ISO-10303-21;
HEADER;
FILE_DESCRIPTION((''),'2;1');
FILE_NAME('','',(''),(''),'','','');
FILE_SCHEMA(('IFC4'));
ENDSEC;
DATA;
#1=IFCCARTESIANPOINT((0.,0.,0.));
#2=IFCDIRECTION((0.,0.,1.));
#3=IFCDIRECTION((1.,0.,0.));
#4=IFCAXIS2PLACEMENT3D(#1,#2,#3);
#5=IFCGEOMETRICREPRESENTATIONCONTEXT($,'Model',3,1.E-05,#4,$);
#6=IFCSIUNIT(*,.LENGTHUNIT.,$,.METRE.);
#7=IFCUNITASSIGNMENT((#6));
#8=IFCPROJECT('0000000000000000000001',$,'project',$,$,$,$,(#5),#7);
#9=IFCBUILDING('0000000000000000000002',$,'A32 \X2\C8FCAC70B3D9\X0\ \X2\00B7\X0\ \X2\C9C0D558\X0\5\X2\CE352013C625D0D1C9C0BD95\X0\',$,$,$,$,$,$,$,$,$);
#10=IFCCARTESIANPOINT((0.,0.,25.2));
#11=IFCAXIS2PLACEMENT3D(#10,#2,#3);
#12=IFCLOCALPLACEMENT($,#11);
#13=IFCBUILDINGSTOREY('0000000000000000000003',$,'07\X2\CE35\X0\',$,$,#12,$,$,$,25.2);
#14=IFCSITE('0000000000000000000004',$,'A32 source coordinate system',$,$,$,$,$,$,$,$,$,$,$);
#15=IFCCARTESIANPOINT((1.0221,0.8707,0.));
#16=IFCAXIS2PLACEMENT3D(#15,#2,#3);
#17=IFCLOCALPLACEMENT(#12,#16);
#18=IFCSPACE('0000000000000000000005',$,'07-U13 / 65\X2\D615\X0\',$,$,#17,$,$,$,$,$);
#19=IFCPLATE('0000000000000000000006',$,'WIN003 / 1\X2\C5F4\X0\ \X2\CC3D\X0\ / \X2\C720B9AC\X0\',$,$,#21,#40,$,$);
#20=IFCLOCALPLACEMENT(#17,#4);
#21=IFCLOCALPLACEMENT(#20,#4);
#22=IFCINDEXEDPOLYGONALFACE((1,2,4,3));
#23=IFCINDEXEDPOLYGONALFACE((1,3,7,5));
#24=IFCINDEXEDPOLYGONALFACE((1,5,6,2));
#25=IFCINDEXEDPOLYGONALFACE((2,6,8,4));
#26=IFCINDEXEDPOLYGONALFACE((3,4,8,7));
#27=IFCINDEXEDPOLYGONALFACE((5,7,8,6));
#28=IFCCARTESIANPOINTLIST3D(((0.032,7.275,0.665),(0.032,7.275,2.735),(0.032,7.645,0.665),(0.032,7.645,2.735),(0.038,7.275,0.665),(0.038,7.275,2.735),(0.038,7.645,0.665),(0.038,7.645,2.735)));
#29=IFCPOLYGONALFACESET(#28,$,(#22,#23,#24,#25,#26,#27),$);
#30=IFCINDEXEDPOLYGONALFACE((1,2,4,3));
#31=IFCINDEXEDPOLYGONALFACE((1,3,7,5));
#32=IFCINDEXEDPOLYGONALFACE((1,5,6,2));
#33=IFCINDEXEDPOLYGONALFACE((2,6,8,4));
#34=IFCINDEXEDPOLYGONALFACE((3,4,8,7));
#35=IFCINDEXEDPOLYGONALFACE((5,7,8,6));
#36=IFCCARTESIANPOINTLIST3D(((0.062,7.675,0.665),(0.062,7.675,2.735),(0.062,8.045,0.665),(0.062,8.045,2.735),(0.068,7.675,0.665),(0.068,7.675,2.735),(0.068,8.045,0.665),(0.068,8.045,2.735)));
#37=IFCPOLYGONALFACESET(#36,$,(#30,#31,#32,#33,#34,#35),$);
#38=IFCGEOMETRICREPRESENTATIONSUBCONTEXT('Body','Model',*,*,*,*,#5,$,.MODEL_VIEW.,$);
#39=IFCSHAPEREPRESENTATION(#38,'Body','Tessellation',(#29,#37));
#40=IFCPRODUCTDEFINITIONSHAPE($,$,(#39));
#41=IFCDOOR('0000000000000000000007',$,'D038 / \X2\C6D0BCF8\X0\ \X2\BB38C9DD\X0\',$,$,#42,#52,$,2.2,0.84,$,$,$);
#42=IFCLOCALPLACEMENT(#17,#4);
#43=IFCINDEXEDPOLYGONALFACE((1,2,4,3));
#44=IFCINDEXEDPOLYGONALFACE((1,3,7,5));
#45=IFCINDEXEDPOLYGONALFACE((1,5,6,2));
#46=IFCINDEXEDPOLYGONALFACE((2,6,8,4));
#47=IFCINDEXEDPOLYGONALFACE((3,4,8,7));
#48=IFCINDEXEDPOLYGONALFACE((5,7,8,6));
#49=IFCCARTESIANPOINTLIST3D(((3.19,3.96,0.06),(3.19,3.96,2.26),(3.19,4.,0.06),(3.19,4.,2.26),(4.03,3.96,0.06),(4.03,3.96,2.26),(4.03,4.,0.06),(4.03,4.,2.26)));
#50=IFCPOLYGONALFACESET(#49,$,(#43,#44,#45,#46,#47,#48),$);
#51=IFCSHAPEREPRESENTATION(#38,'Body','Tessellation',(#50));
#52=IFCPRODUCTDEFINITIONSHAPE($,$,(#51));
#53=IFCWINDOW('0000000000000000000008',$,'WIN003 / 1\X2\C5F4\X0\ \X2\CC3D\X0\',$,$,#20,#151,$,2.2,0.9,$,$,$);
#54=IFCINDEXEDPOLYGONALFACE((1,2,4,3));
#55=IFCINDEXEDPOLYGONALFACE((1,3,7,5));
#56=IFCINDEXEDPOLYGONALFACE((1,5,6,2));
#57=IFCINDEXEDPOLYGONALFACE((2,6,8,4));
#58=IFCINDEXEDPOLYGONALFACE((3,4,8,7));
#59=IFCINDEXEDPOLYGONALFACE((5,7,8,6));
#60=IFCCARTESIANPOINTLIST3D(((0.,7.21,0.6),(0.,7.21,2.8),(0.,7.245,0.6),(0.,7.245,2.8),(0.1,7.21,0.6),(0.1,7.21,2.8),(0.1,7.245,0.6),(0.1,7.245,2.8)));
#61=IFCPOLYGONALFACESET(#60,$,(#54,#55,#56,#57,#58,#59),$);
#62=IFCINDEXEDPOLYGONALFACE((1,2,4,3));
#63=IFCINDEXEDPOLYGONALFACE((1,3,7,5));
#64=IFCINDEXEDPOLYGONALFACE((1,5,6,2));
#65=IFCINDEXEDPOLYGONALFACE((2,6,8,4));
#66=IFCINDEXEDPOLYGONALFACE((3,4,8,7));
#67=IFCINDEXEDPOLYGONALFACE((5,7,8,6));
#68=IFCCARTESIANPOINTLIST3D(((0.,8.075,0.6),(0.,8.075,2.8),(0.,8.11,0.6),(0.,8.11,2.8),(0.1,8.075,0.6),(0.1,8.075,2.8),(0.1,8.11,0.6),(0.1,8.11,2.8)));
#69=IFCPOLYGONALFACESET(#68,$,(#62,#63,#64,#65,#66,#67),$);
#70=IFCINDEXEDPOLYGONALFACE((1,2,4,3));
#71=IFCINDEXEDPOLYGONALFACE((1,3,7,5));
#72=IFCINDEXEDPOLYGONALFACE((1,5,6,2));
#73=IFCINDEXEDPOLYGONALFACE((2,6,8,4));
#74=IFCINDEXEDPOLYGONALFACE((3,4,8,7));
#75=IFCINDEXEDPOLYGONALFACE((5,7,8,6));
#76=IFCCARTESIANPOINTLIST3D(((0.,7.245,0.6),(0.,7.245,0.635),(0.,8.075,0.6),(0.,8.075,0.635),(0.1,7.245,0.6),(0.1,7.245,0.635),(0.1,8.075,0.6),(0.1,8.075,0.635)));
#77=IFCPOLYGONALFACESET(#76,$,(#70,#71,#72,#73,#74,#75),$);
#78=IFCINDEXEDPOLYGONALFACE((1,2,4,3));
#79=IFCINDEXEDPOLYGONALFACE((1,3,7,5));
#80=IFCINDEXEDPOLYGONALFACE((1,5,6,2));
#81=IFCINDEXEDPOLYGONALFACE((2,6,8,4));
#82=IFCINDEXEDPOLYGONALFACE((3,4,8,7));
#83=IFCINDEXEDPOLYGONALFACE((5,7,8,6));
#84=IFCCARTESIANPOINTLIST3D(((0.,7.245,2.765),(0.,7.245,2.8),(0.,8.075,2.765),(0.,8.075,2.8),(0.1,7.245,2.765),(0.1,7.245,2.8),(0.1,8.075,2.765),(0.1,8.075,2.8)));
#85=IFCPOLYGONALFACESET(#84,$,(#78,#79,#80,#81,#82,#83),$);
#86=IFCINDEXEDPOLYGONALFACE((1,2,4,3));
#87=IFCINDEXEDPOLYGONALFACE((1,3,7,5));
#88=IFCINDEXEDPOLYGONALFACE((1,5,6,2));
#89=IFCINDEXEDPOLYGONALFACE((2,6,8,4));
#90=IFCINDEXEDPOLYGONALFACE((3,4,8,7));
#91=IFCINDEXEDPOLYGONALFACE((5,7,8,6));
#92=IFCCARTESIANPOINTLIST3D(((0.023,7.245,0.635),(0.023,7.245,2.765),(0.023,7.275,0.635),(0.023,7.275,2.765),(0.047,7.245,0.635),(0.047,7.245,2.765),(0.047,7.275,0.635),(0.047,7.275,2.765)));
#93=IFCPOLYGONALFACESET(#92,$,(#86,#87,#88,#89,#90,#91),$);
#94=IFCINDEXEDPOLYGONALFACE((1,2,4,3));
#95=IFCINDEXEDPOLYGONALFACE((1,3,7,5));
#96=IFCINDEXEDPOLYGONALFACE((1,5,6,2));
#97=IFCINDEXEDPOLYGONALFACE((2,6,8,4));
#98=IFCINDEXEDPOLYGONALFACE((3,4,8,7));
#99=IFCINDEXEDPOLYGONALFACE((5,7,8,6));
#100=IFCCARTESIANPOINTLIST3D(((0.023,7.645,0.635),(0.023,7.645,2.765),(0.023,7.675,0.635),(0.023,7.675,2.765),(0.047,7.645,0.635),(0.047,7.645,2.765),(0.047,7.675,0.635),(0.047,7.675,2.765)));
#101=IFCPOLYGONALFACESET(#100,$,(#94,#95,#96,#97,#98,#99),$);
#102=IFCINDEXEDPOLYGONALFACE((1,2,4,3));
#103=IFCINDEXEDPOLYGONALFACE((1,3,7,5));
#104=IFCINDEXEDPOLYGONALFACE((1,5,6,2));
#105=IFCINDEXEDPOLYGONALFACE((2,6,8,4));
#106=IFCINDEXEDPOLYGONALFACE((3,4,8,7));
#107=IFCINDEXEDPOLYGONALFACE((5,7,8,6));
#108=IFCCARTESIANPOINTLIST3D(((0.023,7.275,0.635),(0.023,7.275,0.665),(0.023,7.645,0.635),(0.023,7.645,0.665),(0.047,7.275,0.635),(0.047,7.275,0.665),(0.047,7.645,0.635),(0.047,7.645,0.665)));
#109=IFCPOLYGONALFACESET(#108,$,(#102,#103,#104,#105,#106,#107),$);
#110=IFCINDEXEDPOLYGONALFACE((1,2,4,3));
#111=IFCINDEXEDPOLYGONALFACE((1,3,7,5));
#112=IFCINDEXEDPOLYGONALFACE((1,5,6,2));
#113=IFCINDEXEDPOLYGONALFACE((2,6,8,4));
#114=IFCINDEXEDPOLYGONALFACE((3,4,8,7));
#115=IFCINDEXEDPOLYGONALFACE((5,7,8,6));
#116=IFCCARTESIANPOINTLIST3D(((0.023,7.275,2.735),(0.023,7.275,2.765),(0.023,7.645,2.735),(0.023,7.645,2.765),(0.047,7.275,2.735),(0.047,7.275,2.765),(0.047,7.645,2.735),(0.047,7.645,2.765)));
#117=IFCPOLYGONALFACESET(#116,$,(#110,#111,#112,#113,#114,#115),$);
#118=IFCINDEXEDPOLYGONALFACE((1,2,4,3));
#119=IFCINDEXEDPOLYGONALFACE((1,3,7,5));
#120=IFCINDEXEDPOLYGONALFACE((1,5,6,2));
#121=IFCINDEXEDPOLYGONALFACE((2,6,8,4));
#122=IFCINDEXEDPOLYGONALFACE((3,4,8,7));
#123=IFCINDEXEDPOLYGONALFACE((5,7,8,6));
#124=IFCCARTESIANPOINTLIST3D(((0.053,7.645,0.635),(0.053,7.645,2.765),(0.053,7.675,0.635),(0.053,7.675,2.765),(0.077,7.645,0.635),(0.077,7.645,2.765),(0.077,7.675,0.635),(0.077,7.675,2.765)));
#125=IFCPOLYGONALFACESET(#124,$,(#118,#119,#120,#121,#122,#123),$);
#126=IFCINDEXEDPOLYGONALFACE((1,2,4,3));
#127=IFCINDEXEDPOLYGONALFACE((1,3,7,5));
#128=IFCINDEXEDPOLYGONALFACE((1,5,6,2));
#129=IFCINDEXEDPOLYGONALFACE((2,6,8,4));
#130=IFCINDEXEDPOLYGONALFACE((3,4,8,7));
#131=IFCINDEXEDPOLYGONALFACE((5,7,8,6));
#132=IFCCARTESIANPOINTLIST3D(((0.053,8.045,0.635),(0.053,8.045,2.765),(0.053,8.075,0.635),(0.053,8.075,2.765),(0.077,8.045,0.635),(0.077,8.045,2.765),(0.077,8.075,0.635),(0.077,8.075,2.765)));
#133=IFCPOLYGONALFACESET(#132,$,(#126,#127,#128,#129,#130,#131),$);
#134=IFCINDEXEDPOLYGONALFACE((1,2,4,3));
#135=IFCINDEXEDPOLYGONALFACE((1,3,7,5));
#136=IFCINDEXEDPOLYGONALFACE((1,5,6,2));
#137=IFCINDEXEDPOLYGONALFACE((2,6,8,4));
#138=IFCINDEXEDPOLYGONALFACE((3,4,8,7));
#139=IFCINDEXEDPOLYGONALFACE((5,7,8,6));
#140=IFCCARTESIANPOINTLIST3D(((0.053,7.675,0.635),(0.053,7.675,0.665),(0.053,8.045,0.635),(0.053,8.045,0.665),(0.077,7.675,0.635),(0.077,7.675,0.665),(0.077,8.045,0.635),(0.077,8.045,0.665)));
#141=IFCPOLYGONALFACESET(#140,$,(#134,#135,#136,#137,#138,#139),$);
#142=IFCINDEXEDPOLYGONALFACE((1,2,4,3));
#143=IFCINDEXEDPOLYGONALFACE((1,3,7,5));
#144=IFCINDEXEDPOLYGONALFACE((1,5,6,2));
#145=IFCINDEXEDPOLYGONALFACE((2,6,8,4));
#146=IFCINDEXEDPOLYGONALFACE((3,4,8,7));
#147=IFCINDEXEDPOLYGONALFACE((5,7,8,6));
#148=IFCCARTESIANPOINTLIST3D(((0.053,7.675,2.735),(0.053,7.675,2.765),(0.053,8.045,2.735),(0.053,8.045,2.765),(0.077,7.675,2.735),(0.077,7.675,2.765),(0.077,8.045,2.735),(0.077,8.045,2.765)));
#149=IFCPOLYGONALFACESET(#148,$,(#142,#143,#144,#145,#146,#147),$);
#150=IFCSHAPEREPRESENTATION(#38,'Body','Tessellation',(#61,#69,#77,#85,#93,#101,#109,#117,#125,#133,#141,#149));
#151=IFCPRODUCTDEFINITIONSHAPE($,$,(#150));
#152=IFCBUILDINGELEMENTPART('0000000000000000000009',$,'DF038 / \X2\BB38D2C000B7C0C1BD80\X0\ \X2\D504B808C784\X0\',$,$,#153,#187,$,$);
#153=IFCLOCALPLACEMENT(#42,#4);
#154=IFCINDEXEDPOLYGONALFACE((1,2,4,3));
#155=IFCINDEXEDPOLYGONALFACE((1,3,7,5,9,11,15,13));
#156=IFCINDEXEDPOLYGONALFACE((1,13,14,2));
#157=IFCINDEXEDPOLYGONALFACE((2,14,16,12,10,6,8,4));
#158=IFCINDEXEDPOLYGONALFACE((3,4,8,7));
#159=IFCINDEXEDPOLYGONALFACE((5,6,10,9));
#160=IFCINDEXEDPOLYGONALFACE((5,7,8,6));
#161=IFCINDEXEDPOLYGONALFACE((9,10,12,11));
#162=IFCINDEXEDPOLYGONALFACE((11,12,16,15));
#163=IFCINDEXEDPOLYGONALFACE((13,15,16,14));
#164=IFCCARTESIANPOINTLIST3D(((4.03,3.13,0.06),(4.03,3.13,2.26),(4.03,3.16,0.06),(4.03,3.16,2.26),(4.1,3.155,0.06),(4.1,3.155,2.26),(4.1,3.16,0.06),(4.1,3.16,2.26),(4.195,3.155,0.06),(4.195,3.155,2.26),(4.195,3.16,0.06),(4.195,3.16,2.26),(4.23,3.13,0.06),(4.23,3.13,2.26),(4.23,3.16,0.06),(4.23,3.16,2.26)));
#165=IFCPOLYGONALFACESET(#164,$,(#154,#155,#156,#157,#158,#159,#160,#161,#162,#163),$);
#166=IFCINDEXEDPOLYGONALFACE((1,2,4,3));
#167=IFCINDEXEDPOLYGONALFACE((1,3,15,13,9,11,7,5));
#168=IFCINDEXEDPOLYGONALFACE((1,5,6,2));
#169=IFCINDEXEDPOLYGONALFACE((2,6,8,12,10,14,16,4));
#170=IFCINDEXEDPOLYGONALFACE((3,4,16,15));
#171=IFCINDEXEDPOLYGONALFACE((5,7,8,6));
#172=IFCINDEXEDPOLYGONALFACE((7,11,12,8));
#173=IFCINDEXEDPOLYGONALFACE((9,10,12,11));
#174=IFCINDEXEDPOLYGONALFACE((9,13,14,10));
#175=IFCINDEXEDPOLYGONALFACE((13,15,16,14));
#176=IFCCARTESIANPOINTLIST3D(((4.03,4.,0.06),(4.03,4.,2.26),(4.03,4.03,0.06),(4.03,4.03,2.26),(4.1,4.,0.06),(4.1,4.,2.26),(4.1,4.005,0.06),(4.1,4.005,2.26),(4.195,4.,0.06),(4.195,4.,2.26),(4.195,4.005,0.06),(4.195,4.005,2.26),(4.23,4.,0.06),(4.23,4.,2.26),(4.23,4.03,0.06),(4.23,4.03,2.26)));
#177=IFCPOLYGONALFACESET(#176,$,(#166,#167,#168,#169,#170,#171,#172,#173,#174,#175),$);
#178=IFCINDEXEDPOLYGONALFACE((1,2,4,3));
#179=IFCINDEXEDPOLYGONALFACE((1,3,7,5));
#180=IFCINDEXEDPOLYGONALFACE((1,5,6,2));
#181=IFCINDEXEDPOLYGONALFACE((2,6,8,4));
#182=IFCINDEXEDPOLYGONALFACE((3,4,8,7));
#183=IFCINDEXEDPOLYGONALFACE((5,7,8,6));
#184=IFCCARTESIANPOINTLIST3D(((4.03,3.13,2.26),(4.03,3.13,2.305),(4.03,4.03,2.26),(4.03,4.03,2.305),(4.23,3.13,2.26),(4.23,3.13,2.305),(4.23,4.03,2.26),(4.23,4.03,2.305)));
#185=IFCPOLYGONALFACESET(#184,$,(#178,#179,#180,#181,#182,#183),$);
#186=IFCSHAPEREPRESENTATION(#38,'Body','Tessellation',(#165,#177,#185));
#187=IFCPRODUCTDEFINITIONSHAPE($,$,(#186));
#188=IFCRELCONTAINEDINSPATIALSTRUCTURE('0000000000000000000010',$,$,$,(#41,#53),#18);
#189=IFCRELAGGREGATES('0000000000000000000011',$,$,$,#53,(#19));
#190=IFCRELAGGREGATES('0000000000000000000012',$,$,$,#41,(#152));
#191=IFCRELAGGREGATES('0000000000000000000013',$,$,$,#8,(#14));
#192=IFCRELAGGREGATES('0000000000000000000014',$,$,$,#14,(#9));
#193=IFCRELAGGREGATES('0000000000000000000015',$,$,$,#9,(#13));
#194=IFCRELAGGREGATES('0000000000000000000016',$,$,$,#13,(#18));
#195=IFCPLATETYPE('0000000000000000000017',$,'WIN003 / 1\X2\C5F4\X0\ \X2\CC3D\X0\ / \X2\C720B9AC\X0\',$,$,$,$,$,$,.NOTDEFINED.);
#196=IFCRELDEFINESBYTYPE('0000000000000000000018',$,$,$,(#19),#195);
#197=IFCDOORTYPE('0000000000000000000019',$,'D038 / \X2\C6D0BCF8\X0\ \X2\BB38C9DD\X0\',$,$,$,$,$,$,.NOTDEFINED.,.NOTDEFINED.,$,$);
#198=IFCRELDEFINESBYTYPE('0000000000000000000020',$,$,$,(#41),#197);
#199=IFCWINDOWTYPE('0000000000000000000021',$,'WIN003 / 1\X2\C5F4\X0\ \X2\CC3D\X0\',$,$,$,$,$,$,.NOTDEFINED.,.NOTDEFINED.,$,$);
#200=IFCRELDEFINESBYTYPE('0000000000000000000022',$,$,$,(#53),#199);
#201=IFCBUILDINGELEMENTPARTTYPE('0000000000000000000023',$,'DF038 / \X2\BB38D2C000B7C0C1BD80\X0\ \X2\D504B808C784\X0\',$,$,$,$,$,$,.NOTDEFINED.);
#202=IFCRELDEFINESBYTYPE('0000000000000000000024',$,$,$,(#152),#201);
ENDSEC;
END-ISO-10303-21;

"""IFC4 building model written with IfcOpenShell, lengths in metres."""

from ifc_helpers import new_model, si_unit, frame, origin, origin_with_axes, place, context, subcontext, project, spatial, polyline, outline, extrude, source, transform, mapped, type_object, type_shapes, element, aggregate, save


model = new_model("IFC4")

# Units and contexts
model_context = context("Model", 3, precision=1e-05, world=origin_with_axes())
body_context = subcontext(model_context, "Body", "Model", "MODEL_VIEW")
ifc_project = project(units=[si_unit("LENGTHUNIT", "METRE")], contexts=[model_context])

# Plate
storey_placement = place(None, frame((0.0, 0.0, 25.2), z_axis=(0.0, 0.0, 1.0), x_axis=(1.0, 0.0, 0.0)))
space_placement = place(storey_placement, frame((1.0221, 0.8707, 0.0), z_axis=(0.0, 0.0, 1.0), x_axis=(1.0, 0.0, 0.0)))
plate_type_1 = type_object("IfcPlateType", Name="WIN003 / 1열 창 / 유리", PredefinedType="NOTDEFINED")
shared_shape_1 = source(origin(), body_context, "Body", "SweptSolid", [
    extrude(outline(polyline([(0.032, 7.275), (0.032, 7.645), (0.038, 7.645), (0.038, 7.275), (0.032, 7.275)])), frame((0.0, 0.0, 0.665)), (0.0, 0.0, 1.0), 2.07),
    extrude(outline(polyline([(0.062, 7.675), (0.062, 8.045), (0.068, 8.045), (0.068, 7.675), (0.062, 7.675)])), frame((0.0, 0.0, 0.665)), (0.0, 0.0, 1.0), 2.07),
])
type_shapes(plate_type_1, [shared_shape_1])
window_1_placement = place(space_placement, origin_with_axes())
plate_1_placement = place(window_1_placement, origin_with_axes())
plate_1 = element("IfcPlate", 1, at=plate_1_placement, type_object=plate_type_1, Name="WIN003 / 1열 창 / 유리", context=body_context, shape_type="MappedRepresentation", body=[
    mapped(shared_shape_1, transform((0.0, 0.0, 0.0), scale=1.0)),
])

# Site, building, storey, space
site = spatial("IfcSite", under=ifc_project, Name="A32 source coordinate system")
building = spatial("IfcBuilding", under=site, Name="A32 주거동 · 지하5층–옥탑지붕")
storey = spatial("IfcBuildingStorey", under=building, at=storey_placement, Name="07층", Elevation=25.2)
space = spatial("IfcSpace", under=storey, at=space_placement, Name="07-U13 / 65형")

# Door
door_type_1 = type_object("IfcDoorType", Name="D038 / 원본 문짝", OperationType="NOTDEFINED", PredefinedType="NOTDEFINED")
shared_shape_2 = source(origin(), body_context, "Body", "SweptSolid", [
    extrude(outline(polyline([(3.19, 3.96), (3.19, 4.0), (4.03, 4.0), (4.03, 3.96), (3.19, 3.96)])), frame((0.0, 0.0, 0.06)), (0.0, 0.0, 1.0), 2.2),
])
type_shapes(door_type_1, [shared_shape_2])
door_1_placement = place(space_placement, origin_with_axes())
door_1 = element("IfcDoor", 2, at=door_1_placement, inside=space, type_object=door_type_1, Name="D038 / 원본 문짝", OverallHeight=2.2, OverallWidth=0.84, context=body_context, shape_type="MappedRepresentation", body=[
    mapped(shared_shape_2, transform((0.0, 0.0, 0.0), scale=1.0)),
])

# Window
window_type_1 = type_object("IfcWindowType", Name="WIN003 / 1열 창", PartitioningType="NOTDEFINED", PredefinedType="NOTDEFINED")
shared_shape_3 = source(origin(), body_context, "Body", "SweptSolid", [
    extrude(outline(polyline([(0.0, 7.21), (0.0, 7.245), (0.1, 7.245), (0.1, 7.21), (0.0, 7.21)])), frame((0.0, 0.0, 0.6)), (0.0, 0.0, 1.0), 2.2),
    extrude(outline(polyline([(0.0, 8.075), (0.0, 8.11), (0.1, 8.11), (0.1, 8.075), (0.0, 8.075)])), frame((0.0, 0.0, 0.6)), (0.0, 0.0, 1.0), 2.2),
    extrude(outline(polyline([(0.0, 7.245), (0.0, 8.075), (0.1, 8.075), (0.1, 7.245), (0.0, 7.245)])), frame((0.0, 0.0, 0.6)), (0.0, 0.0, 1.0), 0.035),
    extrude(outline(polyline([(0.0, 7.245), (0.0, 8.075), (0.1, 8.075), (0.1, 7.245), (0.0, 7.245)])), frame((0.0, 0.0, 2.765)), (0.0, 0.0, 1.0), 0.035),
    extrude(outline(polyline([(0.023, 7.245), (0.023, 7.275), (0.047, 7.275), (0.047, 7.245), (0.023, 7.245)])), frame((0.0, 0.0, 0.635)), (0.0, 0.0, 1.0), 2.13),
    extrude(outline(polyline([(0.023, 7.645), (0.023, 7.675), (0.047, 7.675), (0.047, 7.645), (0.023, 7.645)])), frame((0.0, 0.0, 0.635)), (0.0, 0.0, 1.0), 2.13),
    extrude(outline(polyline([(0.023, 7.275), (0.023, 7.645), (0.047, 7.645), (0.047, 7.275), (0.023, 7.275)])), frame((0.0, 0.0, 0.635)), (0.0, 0.0, 1.0), 0.03),
    extrude(outline(polyline([(0.023, 7.275), (0.023, 7.645), (0.047, 7.645), (0.047, 7.275), (0.023, 7.275)])), frame((0.0, 0.0, 2.735)), (0.0, 0.0, 1.0), 0.03),
    extrude(outline(polyline([(0.053, 7.645), (0.053, 7.675), (0.077, 7.675), (0.077, 7.645), (0.053, 7.645)])), frame((0.0, 0.0, 0.635)), (0.0, 0.0, 1.0), 2.13),
    extrude(outline(polyline([(0.053, 8.045), (0.053, 8.075), (0.077, 8.075), (0.077, 8.045), (0.053, 8.045)])), frame((0.0, 0.0, 0.635)), (0.0, 0.0, 1.0), 2.13),
    extrude(outline(polyline([(0.053, 7.675), (0.053, 8.045), (0.077, 8.045), (0.077, 7.675), (0.053, 7.675)])), frame((0.0, 0.0, 0.635)), (0.0, 0.0, 1.0), 0.03),
    extrude(outline(polyline([(0.053, 7.675), (0.053, 8.045), (0.077, 8.045), (0.077, 7.675), (0.053, 7.675)])), frame((0.0, 0.0, 2.735)), (0.0, 0.0, 1.0), 0.03),
])
type_shapes(window_type_1, [shared_shape_3])
window_1 = element("IfcWindow", 3, at=window_1_placement, inside=space, type_object=window_type_1, Name="WIN003 / 1열 창", OverallHeight=2.2, OverallWidth=0.9, context=body_context, shape_type="MappedRepresentation", body=[
    mapped(shared_shape_3, transform((0.0, 0.0, 0.0), scale=1.0)),
])
aggregate(window_1, [plate_1])

# Building element part
building_element_part_type_1 = type_object("IfcBuildingElementPartType", Name="DF038 / 문틀·상부 프레임", PredefinedType="NOTDEFINED")
shared_shape_4 = source(origin(), body_context, "Body", "SweptSolid", [
    extrude(outline(polyline([(4.03, 3.16), (4.1, 3.16), (4.1, 3.155), (4.195, 3.155), (4.195, 3.16), (4.23, 3.16), (4.23, 3.13), (4.03, 3.13), (4.03, 3.16)])), frame((0.0, 0.0, 0.06)), (0.0, 0.0, 1.0), 2.2),
    extrude(outline(polyline([(4.23, 4.03), (4.23, 4.0), (4.195, 4.0), (4.195, 4.005), (4.1, 4.005), (4.1, 4.0), (4.03, 4.0), (4.03, 4.03), (4.23, 4.03)])), frame((0.0, 0.0, 0.06)), (0.0, 0.0, 1.0), 2.2),
    extrude(outline(polyline([(4.03, 3.13), (4.03, 4.03), (4.23, 4.03), (4.23, 3.13), (4.03, 3.13)])), frame((0.0, 0.0, 2.26)), (0.0, 0.0, 1.0), 0.045),
])
type_shapes(building_element_part_type_1, [shared_shape_4])
building_element_part_1_placement = place(door_1_placement, origin_with_axes())
building_element_part_1 = element("IfcBuildingElementPart", 4, at=building_element_part_1_placement, type_object=building_element_part_type_1, Name="DF038 / 문틀·상부 프레임", context=body_context, shape_type="MappedRepresentation", body=[
    mapped(shared_shape_4, transform((0.0, 0.0, 0.0), scale=1.0)),
])
aggregate(door_1, [building_element_part_1])

save(model, "model.ifc")
